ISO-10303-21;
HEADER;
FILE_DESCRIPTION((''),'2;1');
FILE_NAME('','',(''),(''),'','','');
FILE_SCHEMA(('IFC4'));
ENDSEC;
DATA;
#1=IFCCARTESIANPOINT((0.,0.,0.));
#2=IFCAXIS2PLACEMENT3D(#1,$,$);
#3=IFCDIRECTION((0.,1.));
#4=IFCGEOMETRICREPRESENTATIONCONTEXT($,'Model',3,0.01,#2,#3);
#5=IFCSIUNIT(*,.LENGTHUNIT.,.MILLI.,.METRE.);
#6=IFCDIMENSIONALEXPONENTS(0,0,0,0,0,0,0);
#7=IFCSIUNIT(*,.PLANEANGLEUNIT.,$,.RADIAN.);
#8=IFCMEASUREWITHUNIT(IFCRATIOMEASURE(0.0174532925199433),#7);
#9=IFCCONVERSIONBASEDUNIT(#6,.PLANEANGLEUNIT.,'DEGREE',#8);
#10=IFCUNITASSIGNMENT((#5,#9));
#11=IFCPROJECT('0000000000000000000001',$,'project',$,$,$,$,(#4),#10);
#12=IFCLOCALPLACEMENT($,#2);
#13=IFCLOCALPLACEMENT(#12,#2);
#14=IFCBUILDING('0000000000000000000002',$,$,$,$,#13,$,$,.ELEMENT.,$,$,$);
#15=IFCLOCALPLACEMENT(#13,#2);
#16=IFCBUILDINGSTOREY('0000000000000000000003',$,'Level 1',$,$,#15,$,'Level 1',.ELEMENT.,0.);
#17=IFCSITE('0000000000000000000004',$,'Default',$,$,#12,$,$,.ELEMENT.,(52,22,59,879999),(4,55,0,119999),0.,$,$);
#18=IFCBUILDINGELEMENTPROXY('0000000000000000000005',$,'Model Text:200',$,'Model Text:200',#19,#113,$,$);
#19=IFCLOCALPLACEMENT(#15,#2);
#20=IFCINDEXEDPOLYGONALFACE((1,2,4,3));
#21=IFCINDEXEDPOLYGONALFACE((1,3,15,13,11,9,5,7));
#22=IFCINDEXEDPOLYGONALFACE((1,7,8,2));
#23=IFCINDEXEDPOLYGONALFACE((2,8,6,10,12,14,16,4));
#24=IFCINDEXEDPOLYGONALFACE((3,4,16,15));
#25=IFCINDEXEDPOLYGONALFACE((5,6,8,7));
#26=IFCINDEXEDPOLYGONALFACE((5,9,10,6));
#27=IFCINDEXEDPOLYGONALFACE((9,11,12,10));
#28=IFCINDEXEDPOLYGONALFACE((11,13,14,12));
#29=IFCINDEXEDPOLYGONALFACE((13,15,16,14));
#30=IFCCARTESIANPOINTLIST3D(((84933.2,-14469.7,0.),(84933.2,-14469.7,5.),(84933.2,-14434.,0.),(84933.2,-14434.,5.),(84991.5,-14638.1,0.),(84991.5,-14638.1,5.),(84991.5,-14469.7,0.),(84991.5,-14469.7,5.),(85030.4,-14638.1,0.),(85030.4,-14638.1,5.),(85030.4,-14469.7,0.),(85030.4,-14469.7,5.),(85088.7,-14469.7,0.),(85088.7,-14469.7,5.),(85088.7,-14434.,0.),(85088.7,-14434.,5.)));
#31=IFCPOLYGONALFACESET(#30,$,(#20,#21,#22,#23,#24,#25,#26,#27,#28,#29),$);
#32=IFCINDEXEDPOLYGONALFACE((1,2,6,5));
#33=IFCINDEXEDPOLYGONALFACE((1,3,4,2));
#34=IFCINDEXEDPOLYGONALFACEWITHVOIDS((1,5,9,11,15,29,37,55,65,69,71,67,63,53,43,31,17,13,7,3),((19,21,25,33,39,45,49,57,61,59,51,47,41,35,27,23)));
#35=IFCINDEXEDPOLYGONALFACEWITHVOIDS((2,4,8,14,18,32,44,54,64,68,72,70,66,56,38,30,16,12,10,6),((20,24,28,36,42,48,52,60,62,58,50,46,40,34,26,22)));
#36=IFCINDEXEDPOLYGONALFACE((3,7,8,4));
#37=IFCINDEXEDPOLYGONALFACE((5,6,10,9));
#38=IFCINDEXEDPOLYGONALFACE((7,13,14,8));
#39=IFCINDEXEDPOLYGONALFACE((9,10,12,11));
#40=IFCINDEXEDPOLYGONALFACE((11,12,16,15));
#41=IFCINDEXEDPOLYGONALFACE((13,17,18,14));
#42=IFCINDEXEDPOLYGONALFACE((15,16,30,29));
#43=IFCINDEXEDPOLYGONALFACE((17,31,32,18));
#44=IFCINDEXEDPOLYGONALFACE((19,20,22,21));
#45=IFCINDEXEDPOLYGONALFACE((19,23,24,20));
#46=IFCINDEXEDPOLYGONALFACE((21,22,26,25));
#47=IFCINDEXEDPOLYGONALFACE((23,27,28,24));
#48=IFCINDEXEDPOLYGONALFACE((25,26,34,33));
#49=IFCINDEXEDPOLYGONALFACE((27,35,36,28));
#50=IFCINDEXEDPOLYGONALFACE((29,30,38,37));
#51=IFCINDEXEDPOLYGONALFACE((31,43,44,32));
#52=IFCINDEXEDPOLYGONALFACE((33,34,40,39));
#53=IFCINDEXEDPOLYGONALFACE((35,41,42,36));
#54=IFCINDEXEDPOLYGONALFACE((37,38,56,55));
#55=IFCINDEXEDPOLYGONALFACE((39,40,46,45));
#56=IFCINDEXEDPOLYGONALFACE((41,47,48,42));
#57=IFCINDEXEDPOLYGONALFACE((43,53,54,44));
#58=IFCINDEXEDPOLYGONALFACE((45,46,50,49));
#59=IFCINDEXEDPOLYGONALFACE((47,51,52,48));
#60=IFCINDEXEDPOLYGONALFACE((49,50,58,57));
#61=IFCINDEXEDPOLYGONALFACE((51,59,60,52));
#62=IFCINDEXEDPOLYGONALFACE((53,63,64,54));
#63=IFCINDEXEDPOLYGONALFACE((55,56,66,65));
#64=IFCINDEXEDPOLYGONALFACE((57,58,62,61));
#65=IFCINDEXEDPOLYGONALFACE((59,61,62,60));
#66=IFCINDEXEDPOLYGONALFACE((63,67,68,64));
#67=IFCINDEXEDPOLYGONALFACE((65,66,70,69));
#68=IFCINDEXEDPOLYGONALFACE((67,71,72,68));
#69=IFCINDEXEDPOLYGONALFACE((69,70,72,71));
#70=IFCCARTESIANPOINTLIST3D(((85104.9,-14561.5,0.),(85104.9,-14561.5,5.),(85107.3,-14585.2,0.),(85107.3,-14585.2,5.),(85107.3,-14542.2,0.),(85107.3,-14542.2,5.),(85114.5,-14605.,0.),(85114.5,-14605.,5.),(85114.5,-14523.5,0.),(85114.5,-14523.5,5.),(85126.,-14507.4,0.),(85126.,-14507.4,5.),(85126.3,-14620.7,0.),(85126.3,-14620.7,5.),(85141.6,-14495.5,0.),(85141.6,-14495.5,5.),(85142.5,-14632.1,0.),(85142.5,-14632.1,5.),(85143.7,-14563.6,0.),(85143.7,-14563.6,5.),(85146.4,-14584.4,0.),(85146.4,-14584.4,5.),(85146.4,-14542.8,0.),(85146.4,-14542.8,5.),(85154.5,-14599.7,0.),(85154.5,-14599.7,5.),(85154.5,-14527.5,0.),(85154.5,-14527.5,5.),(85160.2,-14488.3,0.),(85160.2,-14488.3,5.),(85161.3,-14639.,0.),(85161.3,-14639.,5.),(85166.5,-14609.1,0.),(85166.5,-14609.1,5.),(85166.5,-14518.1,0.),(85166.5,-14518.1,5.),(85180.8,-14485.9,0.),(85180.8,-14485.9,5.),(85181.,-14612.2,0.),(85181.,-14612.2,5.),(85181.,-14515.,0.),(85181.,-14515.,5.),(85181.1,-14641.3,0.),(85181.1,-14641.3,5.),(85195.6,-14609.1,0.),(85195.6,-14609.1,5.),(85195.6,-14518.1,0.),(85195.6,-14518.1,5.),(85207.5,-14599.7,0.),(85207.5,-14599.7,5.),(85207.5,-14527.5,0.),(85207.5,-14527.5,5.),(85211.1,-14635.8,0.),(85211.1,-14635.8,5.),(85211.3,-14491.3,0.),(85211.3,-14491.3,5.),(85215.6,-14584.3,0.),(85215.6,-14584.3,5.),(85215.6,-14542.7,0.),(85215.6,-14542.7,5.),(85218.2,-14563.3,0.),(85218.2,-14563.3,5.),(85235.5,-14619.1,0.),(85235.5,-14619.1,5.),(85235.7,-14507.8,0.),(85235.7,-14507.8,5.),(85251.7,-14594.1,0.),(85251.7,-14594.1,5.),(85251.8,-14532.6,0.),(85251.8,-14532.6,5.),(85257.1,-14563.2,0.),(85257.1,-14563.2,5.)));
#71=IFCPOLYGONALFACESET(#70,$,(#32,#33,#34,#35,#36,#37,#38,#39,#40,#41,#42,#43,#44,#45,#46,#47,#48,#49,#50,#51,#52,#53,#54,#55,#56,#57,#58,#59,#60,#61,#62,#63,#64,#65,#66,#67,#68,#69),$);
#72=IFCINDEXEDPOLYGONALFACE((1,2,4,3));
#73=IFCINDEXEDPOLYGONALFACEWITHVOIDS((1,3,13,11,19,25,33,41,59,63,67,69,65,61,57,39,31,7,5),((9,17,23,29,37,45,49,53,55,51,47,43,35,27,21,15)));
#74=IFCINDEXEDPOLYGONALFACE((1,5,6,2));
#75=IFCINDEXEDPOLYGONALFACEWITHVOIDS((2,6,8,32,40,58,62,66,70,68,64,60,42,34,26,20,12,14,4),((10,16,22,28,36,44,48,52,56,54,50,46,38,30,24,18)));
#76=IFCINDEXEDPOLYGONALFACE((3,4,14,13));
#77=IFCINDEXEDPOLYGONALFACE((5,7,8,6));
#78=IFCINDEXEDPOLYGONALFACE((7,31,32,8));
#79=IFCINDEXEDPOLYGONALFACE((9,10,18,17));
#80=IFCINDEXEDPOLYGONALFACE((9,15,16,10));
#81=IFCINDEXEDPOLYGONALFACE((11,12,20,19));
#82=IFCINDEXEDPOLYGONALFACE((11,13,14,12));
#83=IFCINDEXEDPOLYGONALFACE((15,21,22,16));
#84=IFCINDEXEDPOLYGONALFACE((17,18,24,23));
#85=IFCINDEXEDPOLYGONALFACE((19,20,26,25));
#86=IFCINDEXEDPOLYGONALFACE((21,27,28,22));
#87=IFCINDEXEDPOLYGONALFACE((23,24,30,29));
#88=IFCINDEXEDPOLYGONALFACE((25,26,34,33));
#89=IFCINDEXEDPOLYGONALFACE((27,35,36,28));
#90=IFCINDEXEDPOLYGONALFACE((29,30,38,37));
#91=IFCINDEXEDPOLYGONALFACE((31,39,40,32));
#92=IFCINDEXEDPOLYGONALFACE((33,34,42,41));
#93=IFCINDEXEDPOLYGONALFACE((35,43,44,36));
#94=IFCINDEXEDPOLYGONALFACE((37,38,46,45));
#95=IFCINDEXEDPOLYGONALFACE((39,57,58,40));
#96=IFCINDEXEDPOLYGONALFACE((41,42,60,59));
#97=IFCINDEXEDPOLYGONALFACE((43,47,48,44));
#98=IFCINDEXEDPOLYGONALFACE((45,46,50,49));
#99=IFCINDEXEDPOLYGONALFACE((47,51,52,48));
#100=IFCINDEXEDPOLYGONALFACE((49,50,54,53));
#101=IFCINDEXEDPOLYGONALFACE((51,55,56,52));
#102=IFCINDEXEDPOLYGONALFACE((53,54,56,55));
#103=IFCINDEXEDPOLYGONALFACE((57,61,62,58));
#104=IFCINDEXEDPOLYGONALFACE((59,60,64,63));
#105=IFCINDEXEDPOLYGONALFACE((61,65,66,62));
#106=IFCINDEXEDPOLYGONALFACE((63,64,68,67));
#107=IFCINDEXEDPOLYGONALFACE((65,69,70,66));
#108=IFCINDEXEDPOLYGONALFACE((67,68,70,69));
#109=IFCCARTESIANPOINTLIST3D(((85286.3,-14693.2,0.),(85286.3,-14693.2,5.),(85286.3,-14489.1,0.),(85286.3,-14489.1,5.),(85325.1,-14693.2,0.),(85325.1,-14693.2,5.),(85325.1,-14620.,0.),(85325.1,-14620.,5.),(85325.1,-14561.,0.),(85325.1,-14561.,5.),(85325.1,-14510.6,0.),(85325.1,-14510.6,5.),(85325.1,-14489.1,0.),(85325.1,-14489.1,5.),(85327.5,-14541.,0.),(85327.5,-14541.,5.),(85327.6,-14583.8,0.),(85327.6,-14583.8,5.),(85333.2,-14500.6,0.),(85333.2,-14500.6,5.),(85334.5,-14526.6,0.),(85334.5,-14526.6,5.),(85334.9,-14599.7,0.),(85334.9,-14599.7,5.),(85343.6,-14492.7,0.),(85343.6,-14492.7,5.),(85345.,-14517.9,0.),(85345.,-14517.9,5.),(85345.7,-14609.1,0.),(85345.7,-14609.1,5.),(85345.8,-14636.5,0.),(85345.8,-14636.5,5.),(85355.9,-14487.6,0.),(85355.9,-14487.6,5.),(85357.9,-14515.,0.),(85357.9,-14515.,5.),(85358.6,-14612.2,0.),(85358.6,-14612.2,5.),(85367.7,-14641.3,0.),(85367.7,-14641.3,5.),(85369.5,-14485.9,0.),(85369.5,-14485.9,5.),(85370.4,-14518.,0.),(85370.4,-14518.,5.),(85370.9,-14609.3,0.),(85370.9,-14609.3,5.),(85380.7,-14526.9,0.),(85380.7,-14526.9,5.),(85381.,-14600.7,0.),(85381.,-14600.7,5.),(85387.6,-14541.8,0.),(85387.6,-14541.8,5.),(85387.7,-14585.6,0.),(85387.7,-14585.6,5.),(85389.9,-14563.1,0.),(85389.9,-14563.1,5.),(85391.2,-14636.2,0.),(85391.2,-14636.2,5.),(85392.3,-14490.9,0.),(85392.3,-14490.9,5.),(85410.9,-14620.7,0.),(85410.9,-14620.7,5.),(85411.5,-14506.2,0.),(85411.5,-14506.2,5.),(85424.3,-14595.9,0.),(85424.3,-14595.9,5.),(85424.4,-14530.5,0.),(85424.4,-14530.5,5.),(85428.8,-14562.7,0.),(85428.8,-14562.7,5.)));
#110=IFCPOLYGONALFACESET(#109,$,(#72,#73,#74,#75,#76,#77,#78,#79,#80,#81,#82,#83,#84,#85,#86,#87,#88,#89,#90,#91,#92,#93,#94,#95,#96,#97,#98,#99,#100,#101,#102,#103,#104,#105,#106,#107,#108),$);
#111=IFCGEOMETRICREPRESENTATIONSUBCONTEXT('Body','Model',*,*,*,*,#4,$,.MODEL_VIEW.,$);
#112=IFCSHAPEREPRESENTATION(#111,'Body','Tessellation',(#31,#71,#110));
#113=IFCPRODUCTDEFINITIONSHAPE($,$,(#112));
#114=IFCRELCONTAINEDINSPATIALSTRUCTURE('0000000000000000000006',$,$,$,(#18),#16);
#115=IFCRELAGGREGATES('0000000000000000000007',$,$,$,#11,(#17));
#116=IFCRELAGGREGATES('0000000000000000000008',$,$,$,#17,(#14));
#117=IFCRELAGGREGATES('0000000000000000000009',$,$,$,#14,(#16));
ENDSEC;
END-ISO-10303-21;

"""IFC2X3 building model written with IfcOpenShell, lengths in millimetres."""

from ifc_helpers import new_model, entity, si_unit, converted_unit, direction, frame, origin, place, context, subcontext, project, spatial, polyline, outline, extrude, element, save


model = new_model("IFC2X3")

# Units and contexts
model_context = context("Model", 3, precision=0.01, world=origin(), true_north=direction((0.0, 1.0)))
body_context = subcontext(model_context, "Body", "Model", "MODEL_VIEW")
ifc_project = project(units=[si_unit("LENGTHUNIT", "METRE", prefix="MILLI"), converted_unit("PLANEANGLEUNIT", "DEGREE", entity("IfcRatioMeasure", 0.0174532925199433), si_unit("PLANEANGLEUNIT", "RADIAN"), dimensions=[0, 0, 0, 0, 0, 0, 0])], contexts=[model_context])

# Site, building, storey
site_placement = place(None, origin())
site = spatial("IfcSite", under=ifc_project, at=site_placement, Name="Default", CompositionType="ELEMENT", RefLatitude=(52, 22, 59, 879999), RefLongitude=(4, 55, 0, 119999), RefElevation=0.0)
building_placement = place(site_placement, origin())
building = spatial("IfcBuilding", under=site, at=building_placement, CompositionType="ELEMENT")
storey_placement = place(building_placement, origin())
storey = spatial("IfcBuildingStorey", under=building, at=storey_placement, Name="Level 1", LongName="Level 1", CompositionType="ELEMENT", Elevation=0.0)

# Building element proxy
proxy_1_placement = place(building_placement, origin())
element("IfcBuildingElementProxy", 1, at=proxy_1_placement, inside=storey, Name="Model Text:200", ObjectType="Model Text:200", context=body_context, shape_type="SweptSolid", body=[
    extrude(outline(polyline([(-19.4, -135.2), (19.4, -135.2), (19.4, 33.2), (77.7, 33.2), (77.7, 68.8), (-77.7, 68.8), (-77.7, 33.2), (-19.4, 33.2), (-19.4, -135.2)])), frame((85010.9, -14502.9, 0.0)), (0.0, 0.0, 1.0), 5.0),
    extrude(outline(polyline([(-8.8, -65.7), (15.1, -65.7), (35.5, -60.5), (52.3, -50.4), (65.3, -35.4), (74.1, -17.3), (78.4, 2.1), (75.9, 32.5), (61.8, 58.5), (38.4, 77.1), (8.3, 85.6), (-22.7, 83.3), (-49.0, 69.9), (-67.8, 47.3), (-76.3, 17.5), (-76.0, -3.3), (-70.7, -22.5), (-60.5, -39.2), (-45.5, -52.3), (-27.7, -61.4), (-8.8, -65.7)]), holes=[polyline([(-2.7, -27.2), (-23.1, -22.5), (-37.5, -12.9), (-45.7, 0.0), (-47.3, 14.8), (-42.7, 28.9), (-32.2, 39.9), (-16.3, 46.3), (4.5, 46.9), (25.1, 42.1), (39.6, 32.6), (47.7, 19.7), (49.4, 5.0), (44.8, -9.2), (34.2, -20.2), (18.2, -26.7), (-2.7, -27.2)])]), frame((85171.1, -14563.6, 0.0), z_axis=(0.0, 0.0, 1.0), x_axis=(0.100608, -0.994926, 0.0)), (0.0, 0.0, 1.0), 5.0),
    extrude(outline(polyline([(-73.1, -75.4), (130.9, -75.4), (130.9, -36.6), (57.8, -36.6), (74.3, -15.9), (79.1, 6.0), (73.9, 29.5), (58.4, 49.2), (33.6, 62.6), (0.5, 67.1), (-31.8, 62.8), (-56.1, 49.8), (-71.3, 30.7), (-76.4, 7.8), (-74.7, -5.8), (-69.6, -18.1), (-61.7, -28.5), (-51.7, -36.6), (-73.1, -36.6), (-73.1, -75.4)]), holes=[polyline([(-1.2, -36.6), (-21.2, -34.2), (-35.6, -27.2), (-44.3, -16.7), (-47.2, -3.8), (-44.3, 8.7), (-35.4, 19.0), (-20.4, 25.9), (0.8, 28.2), (23.3, 26.0), (38.5, 19.3), (47.1, 9.2), (49.9, -3.1), (46.8, -16.0), (37.4, -26.8), (21.5, -34.1), (-1.2, -36.6)])]), frame((85361.7, -14562.3, 0.0), z_axis=(0.0, 0.0, 1.0), x_axis=(0.0, -1.0, 0.0)), (0.0, 0.0, 1.0), 5.0),
])

save(model, "model.ifc")
